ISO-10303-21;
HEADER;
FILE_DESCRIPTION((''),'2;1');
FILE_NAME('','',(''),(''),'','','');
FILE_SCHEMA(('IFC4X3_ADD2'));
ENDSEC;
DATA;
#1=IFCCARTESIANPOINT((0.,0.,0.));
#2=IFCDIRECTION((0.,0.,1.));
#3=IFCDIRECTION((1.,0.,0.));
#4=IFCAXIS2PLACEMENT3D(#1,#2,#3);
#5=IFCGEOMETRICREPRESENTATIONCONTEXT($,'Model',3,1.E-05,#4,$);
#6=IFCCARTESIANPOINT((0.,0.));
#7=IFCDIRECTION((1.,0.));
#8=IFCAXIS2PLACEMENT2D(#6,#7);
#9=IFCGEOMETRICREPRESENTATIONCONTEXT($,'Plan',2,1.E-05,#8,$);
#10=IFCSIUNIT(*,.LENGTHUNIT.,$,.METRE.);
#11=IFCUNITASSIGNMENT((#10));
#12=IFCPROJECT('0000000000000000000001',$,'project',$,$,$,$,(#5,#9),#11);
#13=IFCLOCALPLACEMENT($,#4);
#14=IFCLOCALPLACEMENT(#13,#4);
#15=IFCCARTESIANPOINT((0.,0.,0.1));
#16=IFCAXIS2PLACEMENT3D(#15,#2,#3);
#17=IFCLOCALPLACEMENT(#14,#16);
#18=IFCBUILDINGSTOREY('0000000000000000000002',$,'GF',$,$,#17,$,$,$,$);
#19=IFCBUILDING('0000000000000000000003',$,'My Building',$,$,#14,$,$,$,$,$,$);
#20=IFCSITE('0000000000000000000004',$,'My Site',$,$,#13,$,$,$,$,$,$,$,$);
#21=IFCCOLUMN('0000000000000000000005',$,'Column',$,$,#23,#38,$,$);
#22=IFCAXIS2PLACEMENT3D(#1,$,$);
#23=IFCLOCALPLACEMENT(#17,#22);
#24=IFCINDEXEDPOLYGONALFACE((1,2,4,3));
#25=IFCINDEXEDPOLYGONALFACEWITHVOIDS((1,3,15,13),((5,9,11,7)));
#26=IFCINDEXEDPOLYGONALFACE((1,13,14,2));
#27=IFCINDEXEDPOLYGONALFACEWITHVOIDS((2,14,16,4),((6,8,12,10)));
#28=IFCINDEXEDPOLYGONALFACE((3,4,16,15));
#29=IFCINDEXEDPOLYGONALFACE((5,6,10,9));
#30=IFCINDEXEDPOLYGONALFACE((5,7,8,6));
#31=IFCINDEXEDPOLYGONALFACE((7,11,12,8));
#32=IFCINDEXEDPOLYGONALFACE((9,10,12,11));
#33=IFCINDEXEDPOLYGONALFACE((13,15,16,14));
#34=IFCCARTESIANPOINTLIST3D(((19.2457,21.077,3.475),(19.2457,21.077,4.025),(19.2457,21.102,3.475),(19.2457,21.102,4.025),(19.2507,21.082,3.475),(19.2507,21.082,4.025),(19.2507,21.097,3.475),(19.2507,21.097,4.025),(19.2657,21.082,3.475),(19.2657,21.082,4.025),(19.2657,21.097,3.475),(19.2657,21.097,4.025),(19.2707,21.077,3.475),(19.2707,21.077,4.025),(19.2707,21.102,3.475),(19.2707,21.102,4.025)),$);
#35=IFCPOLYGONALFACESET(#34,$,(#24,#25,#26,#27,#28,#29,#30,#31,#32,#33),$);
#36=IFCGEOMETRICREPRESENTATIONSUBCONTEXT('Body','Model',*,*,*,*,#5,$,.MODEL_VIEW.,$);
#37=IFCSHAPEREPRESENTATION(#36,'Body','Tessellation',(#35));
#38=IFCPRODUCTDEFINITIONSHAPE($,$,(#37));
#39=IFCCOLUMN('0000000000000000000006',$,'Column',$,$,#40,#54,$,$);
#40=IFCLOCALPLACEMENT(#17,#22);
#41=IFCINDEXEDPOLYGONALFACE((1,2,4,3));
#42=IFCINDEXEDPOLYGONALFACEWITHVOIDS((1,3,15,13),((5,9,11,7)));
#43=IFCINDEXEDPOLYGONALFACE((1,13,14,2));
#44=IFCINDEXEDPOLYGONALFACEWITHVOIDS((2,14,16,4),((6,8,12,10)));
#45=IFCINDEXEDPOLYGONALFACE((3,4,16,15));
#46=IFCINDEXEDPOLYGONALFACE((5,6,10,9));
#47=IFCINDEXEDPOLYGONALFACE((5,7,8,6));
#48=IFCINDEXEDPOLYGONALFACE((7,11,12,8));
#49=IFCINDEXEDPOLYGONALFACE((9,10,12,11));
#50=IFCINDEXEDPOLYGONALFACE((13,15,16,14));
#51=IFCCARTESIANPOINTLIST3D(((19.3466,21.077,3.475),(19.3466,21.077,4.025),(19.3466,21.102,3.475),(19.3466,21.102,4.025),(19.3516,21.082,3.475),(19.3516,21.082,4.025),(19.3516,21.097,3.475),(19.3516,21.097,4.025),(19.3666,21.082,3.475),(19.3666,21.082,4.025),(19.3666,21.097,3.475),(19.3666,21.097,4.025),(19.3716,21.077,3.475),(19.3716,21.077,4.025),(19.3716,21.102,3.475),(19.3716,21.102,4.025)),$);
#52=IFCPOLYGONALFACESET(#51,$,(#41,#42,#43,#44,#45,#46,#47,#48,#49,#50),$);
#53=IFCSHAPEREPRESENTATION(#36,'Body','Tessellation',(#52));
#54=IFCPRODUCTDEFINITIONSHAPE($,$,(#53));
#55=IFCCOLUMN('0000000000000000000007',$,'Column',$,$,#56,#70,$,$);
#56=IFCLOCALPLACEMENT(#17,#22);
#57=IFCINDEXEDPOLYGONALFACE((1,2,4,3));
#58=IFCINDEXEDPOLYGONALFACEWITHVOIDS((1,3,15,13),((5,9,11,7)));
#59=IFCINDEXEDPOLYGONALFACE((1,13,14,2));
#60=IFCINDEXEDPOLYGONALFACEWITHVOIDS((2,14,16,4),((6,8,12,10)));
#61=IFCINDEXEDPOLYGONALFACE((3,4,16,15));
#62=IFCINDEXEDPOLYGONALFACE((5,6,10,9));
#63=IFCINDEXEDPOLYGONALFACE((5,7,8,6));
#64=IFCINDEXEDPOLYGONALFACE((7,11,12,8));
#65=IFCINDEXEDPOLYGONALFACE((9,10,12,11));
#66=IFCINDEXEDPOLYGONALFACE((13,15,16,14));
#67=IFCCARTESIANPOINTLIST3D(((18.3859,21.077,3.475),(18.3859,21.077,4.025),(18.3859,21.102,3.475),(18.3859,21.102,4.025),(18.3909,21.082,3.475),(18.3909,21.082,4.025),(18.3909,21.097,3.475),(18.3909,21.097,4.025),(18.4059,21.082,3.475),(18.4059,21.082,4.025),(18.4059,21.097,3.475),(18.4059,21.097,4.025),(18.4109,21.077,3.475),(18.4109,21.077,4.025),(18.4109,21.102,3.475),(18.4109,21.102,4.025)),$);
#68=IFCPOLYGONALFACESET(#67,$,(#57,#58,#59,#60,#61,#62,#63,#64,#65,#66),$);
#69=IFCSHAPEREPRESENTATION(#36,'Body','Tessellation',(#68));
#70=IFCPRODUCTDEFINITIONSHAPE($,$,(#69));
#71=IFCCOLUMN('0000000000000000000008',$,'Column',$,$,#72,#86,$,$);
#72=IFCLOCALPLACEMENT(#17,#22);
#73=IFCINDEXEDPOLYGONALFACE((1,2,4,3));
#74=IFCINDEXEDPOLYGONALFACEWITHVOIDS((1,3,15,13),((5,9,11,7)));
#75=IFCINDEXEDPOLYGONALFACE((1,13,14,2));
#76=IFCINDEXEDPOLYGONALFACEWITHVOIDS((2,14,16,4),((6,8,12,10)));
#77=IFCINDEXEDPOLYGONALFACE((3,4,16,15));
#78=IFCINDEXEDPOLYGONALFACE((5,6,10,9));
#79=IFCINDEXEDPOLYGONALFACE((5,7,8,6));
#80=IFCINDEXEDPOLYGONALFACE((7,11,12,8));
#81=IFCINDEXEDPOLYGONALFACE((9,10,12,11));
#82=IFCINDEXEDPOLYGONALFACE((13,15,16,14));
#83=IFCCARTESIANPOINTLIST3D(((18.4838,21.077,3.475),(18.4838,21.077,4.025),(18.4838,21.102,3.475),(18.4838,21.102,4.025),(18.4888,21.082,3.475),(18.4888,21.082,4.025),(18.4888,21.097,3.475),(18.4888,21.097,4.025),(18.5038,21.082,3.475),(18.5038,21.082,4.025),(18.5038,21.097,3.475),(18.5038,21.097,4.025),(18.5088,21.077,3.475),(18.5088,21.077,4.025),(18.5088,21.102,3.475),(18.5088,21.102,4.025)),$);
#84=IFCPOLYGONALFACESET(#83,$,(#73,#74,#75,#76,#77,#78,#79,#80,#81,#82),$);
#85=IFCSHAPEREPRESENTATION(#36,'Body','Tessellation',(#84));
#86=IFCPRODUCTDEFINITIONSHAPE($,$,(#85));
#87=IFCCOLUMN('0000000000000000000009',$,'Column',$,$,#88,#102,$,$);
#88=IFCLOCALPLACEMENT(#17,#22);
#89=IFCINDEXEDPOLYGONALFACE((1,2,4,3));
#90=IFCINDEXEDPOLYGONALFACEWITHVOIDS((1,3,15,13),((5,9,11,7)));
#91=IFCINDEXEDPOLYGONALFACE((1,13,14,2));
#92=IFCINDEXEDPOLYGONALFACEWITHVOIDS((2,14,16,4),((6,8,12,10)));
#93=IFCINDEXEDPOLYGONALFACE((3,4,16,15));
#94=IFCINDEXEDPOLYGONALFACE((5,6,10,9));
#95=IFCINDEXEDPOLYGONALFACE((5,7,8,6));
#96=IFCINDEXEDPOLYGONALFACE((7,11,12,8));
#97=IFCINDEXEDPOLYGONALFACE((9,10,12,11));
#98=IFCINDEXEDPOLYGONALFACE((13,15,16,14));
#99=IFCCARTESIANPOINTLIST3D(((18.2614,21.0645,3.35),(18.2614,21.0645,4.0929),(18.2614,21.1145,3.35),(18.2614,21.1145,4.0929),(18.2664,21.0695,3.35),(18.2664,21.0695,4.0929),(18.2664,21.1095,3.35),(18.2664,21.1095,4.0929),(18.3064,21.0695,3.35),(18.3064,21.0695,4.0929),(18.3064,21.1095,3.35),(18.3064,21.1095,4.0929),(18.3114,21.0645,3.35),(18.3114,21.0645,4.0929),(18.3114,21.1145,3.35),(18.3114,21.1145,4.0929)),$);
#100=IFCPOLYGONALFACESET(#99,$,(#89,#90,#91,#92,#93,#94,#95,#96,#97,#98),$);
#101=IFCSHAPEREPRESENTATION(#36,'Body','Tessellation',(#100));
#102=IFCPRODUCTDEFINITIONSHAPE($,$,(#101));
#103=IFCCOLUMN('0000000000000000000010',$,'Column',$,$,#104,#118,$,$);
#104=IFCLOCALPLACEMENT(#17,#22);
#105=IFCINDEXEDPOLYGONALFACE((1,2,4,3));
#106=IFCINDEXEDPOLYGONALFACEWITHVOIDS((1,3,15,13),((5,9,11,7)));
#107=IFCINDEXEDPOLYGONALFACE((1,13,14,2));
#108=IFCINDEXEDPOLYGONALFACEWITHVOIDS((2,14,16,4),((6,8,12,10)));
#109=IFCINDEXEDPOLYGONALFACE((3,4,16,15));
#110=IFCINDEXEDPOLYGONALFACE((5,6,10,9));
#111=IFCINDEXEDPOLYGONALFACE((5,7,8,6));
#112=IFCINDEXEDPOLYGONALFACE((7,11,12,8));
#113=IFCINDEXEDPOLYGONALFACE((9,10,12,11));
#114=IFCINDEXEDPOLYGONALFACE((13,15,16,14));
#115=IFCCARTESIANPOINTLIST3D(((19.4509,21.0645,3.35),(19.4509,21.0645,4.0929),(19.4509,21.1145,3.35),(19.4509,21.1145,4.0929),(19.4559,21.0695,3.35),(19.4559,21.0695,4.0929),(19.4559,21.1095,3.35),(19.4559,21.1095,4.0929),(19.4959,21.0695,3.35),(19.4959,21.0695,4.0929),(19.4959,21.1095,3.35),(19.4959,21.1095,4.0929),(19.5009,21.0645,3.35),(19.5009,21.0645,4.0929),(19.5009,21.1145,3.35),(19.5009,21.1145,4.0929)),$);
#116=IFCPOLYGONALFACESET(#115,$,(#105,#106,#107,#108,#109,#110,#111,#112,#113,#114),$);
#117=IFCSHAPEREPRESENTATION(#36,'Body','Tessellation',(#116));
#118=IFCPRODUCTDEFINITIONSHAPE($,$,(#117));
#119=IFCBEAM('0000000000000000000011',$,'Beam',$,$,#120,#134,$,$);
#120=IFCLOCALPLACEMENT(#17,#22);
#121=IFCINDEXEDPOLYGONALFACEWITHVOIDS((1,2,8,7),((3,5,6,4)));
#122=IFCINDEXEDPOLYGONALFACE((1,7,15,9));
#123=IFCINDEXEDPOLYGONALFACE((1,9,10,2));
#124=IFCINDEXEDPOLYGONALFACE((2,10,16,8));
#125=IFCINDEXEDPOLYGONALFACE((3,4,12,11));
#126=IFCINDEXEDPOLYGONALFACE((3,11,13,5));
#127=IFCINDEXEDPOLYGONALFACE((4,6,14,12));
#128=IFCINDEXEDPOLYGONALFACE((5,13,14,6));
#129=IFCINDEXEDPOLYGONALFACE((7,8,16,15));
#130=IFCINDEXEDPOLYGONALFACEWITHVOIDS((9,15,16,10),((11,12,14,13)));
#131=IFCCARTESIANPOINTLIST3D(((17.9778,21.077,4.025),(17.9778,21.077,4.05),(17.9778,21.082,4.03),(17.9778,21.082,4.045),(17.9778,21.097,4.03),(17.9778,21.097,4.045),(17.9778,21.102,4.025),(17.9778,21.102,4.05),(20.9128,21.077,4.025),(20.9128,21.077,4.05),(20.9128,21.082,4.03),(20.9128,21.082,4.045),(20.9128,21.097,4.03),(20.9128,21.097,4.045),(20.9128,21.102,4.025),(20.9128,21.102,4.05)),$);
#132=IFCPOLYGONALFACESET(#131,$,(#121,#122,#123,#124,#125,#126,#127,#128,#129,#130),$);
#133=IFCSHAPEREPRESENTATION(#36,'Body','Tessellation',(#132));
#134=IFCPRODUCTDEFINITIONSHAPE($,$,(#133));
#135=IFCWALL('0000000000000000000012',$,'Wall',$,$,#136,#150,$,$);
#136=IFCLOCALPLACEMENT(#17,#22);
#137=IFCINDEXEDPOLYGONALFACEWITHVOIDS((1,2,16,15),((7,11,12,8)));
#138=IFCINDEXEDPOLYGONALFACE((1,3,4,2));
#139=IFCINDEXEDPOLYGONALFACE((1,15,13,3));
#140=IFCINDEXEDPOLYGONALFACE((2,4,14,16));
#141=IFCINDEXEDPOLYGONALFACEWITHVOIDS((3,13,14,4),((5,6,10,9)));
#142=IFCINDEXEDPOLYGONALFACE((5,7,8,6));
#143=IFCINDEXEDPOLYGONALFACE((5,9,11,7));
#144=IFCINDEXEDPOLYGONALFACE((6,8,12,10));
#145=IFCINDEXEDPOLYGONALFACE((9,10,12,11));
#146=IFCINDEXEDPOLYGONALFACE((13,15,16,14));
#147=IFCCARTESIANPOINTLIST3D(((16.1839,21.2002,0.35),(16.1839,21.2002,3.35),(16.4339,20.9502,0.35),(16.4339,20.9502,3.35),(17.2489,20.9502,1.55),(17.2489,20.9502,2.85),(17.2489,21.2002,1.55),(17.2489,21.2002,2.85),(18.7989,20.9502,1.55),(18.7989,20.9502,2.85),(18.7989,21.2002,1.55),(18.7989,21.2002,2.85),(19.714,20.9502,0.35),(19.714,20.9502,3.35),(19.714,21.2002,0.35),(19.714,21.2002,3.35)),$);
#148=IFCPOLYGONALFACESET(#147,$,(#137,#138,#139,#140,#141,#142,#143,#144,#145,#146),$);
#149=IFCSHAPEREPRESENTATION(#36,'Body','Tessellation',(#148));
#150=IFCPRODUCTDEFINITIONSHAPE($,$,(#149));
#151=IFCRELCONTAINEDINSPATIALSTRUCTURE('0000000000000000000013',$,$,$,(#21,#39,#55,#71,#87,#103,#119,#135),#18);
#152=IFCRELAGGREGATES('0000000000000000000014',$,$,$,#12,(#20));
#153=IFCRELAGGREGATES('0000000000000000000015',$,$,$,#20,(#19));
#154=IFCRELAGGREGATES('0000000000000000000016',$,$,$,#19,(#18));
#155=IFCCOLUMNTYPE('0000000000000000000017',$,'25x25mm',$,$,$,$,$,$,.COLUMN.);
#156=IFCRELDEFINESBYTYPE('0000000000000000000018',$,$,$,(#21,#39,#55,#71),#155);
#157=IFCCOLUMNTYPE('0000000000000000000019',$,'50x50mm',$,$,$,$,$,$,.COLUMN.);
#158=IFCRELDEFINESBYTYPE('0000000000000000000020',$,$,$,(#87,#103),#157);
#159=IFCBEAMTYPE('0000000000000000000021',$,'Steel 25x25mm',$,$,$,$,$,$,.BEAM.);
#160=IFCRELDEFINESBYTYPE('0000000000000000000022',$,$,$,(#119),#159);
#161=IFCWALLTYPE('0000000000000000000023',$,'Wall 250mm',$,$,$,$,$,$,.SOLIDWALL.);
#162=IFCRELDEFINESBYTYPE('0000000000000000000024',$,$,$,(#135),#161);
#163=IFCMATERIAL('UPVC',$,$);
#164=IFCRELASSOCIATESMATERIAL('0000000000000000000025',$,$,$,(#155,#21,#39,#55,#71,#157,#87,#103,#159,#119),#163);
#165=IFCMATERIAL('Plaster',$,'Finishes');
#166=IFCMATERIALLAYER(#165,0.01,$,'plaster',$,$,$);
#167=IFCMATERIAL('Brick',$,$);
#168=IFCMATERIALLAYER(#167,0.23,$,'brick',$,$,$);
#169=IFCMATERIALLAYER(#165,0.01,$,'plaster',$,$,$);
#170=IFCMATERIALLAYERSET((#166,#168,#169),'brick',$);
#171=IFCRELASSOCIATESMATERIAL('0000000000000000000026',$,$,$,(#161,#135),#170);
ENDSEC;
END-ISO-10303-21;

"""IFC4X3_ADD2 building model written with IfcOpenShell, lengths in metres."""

from ifc_helpers import new_model, si_unit, frame, origin_with_axes, origin_2d_with_axis, place, context, subcontext, project, spatial, line, indexed_curve, hollow_rectangle, outline, extrude, source, transform, mapped, material, layer, layer_set, layer_usage, material_profile, profile_set, profile_usage, type_object, element, save


model = new_model("IFC4X3_ADD2")

# Units and contexts
model_context = context("Model", 3, precision=1e-05, world=origin_with_axes())
plan_context = context("Plan", 2, precision=1e-05, world=origin_2d_with_axis())
body_context_1 = subcontext(model_context, "Body", "Model", "MODEL_VIEW")
ifc_project = project(units=[si_unit("LENGTHUNIT", "METRE")], contexts=[model_context, plan_context])

# Site, building, storey
site_placement = place(None, origin_with_axes())
site = spatial("IfcSite", under=ifc_project, at=site_placement, Name="My Site")
building_placement = place(site_placement, origin_with_axes())
building = spatial("IfcBuilding", under=site, at=building_placement, Name="My Building")
storey_placement = place(building_placement, frame((0.0, 0.0, 0.1), z_axis=(0.0, 0.0, 1.0), x_axis=(1.0, 0.0, 0.0)))
storey = spatial("IfcBuildingStorey", under=building, at=storey_placement, Name="GF")

# Columns
ifc_material_1 = material(Name="UPVC")
ifc_material_profile_1 = material_profile(ifc_material_1, hollow_rectangle(XDim=0.025, YDim=0.025, WallThickness=0.005))
ifc_profile_set_1 = profile_set([ifc_material_profile_1])
ifc_profile_usage_1 = profile_usage(ifc_profile_set_1)
column_type_1 = type_object("IfcColumnType", Name="25x25mm", PredefinedType="COLUMN", material=ifc_profile_set_1)
column_1_placement = place(storey_placement, frame((19.2582, 21.0895, 3.475), z_axis=(0.0, 0.0, 1.0), x_axis=(0.0, -1.0, 0.0)))
element("IfcColumn", 1, at=column_1_placement, inside=storey, type_object=column_type_1, material=ifc_profile_usage_1, Name="Column", context=body_context_1, shape_type="SweptSolid", body=[
    extrude(hollow_rectangle(XDim=0.025, YDim=0.025, WallThickness=0.005), origin_with_axes(), (0.0, 0.0, 1.0), 0.55),
])
ifc_profile_usage_2 = profile_usage(ifc_profile_set_1)
column_2_placement = place(storey_placement, frame((19.3591, 21.0895, 3.475), z_axis=(0.0, 0.0, 1.0), x_axis=(0.0, -1.0, 0.0)))
element("IfcColumn", 2, at=column_2_placement, inside=storey, type_object=column_type_1, material=ifc_profile_usage_2, Name="Column", context=body_context_1, shape_type="SweptSolid", body=[
    extrude(hollow_rectangle(XDim=0.025, YDim=0.025, WallThickness=0.005), origin_with_axes(), (0.0, 0.0, 1.0), 0.55),
])
ifc_profile_usage_3 = profile_usage(ifc_profile_set_1)
column_3_placement = place(storey_placement, frame((18.3984, 21.0895, 3.475), z_axis=(0.0, 0.0, 1.0), x_axis=(0.0, -1.0, 0.0)))
element("IfcColumn", 3, at=column_3_placement, inside=storey, type_object=column_type_1, material=ifc_profile_usage_3, Name="Column", context=body_context_1, shape_type="SweptSolid", body=[
    extrude(hollow_rectangle(XDim=0.025, YDim=0.025, WallThickness=0.005), origin_with_axes(), (0.0, 0.0, 1.0), 0.55),
])
ifc_profile_usage_4 = profile_usage(ifc_profile_set_1)
column_4_placement = place(storey_placement, frame((18.4963, 21.0895, 3.475), z_axis=(0.0, 0.0, 1.0), x_axis=(0.0, -1.0, 0.0)))
element("IfcColumn", 4, at=column_4_placement, inside=storey, type_object=column_type_1, material=ifc_profile_usage_4, Name="Column", context=body_context_1, shape_type="SweptSolid", body=[
    extrude(hollow_rectangle(XDim=0.025, YDim=0.025, WallThickness=0.005), origin_with_axes(), (0.0, 0.0, 1.0), 0.55),
])
ifc_material_profile_2 = material_profile(ifc_material_1, hollow_rectangle(XDim=0.05, YDim=0.05, WallThickness=0.005))
ifc_profile_set_2 = profile_set([ifc_material_profile_2])
ifc_profile_usage_5 = profile_usage(ifc_profile_set_2)
column_type_2 = type_object("IfcColumnType", Name="50x50mm", PredefinedType="COLUMN", material=ifc_profile_set_2)
column_5_placement = place(storey_placement, frame((18.2864, 21.0895, 3.35), z_axis=(0.0, 0.0, 1.0), x_axis=(1.0, 0.0, 0.0)))
element("IfcColumn", 5, at=column_5_placement, inside=storey, type_object=column_type_2, material=ifc_profile_usage_5, Name="Column", context=body_context_1, shape_type="SweptSolid", body=[
    extrude(hollow_rectangle(XDim=0.05, YDim=0.05, WallThickness=0.005), origin_with_axes(), (0.0, 0.0, 1.0), 0.7429),
])
ifc_profile_usage_6 = profile_usage(ifc_profile_set_2)
column_6_placement = place(storey_placement, frame((19.4759, 21.0895, 3.35), z_axis=(0.0, 0.0, 1.0), x_axis=(1.0, 0.0, 0.0)))
element("IfcColumn", 6, at=column_6_placement, inside=storey, type_object=column_type_2, material=ifc_profile_usage_6, Name="Column", context=body_context_1, shape_type="SweptSolid", body=[
    extrude(hollow_rectangle(XDim=0.05, YDim=0.05, WallThickness=0.005), origin_with_axes(), (0.0, 0.0, 1.0), 0.7429),
])

# Beam
ifc_material_profile_3 = material_profile(ifc_material_1, hollow_rectangle(XDim=0.025, YDim=0.025, WallThickness=0.005))
ifc_profile_set_3 = profile_set([ifc_material_profile_3])
ifc_profile_usage_7 = profile_usage(ifc_profile_set_3)
beam_type = type_object("IfcBeamType", Name="Steel 25x25mm", PredefinedType="BEAM", material=ifc_profile_set_3)
beam_placement = place(storey_placement, frame((17.9778, 21.0895, 4.0375), z_axis=(1.0, 0.0, 0.0), x_axis=(0.0, 1.0, 0.0)))
element("IfcBeam", 7, at=beam_placement, inside=storey, type_object=beam_type, material=ifc_profile_usage_7, Name="Beam", context=body_context_1, shape_type="SweptSolid", body=[
    extrude(hollow_rectangle(XDim=0.025, YDim=0.025, WallThickness=0.005), origin_with_axes(), (0.0, 0.0, 1.0), 2.9351),
])

# Wall, opening
ifc_material_2 = material(Name="Plaster", Category="Finishes")
ifc_layer_1 = layer(ifc_material_2, 0.01, Name="plaster")
ifc_material_3 = material(Name="Brick")
ifc_layer_2 = layer(ifc_material_3, 0.23, Name="brick")
ifc_layer_3 = layer(ifc_material_2, 0.01, Name="plaster")
ifc_layer_set_1 = layer_set([ifc_layer_1, ifc_layer_2, ifc_layer_3], Name="brick")
ifc_layer_usage_1 = layer_usage(ifc_layer_set_1, "AXIS2", "POSITIVE", 0.0)
wall_type_1 = type_object("IfcWallType", Name="Wall 250mm", PredefinedType="SOLIDWALL", material=ifc_layer_set_1)
wall_1_placement = place(storey_placement, frame((19.714, 21.2002, 0.35), z_axis=(0.0, 0.0, 1.0), x_axis=(-1.0, 0.0, 0.0)))
wall_1 = element("IfcWall", 8, at=wall_1_placement, inside=storey, type_object=wall_type_1, material=ifc_layer_usage_1, Name="Wall", context=body_context_1, shape_type="SweptSolid", body=[
    extrude(outline(indexed_curve([(0.0, 0.0), (0.0, 0.25), (3.28, 0.25), (3.53, 0.0)], segments=[line(1, 2, 3, 4, 1)])), origin_with_axes(), (0.0, 0.0, 1.0), 3.0),
])
shared_shape_1 = source(origin_with_axes(), body_context_1, "Body", "SweptSolid", [
    extrude(outline(indexed_curve([(0.0, 0.0), (1.55, 0.0), (1.55, 1.3), (0.0, 1.3)], segments=[line(1, 2, 3, 4, 1)])), frame((-0.775, -0.6, 0.0), z_axis=(0.0, -1.0, 0.0), x_axis=(1.0, 0.0, 0.0)), (0.0, 0.0, -1.0), 1.2),
])
opening_1_placement = place(wall_1_placement, frame((1.6901, 0.0, 1.2), z_axis=(0.0, 0.0, 1.0), x_axis=(1.0, 0.0, 0.0)))
element("IfcOpeningElement", 9, at=opening_1_placement, cuts=wall_1, PredefinedType="OPENING", context=body_context_1, shape_type="MappedRepresentation", body=[
    mapped(shared_shape_1, transform((0.0, 0.0, 0.0), x_axis=(1.0, 0.0, 0.0), y_axis=(0.0, 1.0, 0.0), z_axis=(0.0, 0.0, 1.0), scale=1.0)),
])

save(model, "model.ifc")
